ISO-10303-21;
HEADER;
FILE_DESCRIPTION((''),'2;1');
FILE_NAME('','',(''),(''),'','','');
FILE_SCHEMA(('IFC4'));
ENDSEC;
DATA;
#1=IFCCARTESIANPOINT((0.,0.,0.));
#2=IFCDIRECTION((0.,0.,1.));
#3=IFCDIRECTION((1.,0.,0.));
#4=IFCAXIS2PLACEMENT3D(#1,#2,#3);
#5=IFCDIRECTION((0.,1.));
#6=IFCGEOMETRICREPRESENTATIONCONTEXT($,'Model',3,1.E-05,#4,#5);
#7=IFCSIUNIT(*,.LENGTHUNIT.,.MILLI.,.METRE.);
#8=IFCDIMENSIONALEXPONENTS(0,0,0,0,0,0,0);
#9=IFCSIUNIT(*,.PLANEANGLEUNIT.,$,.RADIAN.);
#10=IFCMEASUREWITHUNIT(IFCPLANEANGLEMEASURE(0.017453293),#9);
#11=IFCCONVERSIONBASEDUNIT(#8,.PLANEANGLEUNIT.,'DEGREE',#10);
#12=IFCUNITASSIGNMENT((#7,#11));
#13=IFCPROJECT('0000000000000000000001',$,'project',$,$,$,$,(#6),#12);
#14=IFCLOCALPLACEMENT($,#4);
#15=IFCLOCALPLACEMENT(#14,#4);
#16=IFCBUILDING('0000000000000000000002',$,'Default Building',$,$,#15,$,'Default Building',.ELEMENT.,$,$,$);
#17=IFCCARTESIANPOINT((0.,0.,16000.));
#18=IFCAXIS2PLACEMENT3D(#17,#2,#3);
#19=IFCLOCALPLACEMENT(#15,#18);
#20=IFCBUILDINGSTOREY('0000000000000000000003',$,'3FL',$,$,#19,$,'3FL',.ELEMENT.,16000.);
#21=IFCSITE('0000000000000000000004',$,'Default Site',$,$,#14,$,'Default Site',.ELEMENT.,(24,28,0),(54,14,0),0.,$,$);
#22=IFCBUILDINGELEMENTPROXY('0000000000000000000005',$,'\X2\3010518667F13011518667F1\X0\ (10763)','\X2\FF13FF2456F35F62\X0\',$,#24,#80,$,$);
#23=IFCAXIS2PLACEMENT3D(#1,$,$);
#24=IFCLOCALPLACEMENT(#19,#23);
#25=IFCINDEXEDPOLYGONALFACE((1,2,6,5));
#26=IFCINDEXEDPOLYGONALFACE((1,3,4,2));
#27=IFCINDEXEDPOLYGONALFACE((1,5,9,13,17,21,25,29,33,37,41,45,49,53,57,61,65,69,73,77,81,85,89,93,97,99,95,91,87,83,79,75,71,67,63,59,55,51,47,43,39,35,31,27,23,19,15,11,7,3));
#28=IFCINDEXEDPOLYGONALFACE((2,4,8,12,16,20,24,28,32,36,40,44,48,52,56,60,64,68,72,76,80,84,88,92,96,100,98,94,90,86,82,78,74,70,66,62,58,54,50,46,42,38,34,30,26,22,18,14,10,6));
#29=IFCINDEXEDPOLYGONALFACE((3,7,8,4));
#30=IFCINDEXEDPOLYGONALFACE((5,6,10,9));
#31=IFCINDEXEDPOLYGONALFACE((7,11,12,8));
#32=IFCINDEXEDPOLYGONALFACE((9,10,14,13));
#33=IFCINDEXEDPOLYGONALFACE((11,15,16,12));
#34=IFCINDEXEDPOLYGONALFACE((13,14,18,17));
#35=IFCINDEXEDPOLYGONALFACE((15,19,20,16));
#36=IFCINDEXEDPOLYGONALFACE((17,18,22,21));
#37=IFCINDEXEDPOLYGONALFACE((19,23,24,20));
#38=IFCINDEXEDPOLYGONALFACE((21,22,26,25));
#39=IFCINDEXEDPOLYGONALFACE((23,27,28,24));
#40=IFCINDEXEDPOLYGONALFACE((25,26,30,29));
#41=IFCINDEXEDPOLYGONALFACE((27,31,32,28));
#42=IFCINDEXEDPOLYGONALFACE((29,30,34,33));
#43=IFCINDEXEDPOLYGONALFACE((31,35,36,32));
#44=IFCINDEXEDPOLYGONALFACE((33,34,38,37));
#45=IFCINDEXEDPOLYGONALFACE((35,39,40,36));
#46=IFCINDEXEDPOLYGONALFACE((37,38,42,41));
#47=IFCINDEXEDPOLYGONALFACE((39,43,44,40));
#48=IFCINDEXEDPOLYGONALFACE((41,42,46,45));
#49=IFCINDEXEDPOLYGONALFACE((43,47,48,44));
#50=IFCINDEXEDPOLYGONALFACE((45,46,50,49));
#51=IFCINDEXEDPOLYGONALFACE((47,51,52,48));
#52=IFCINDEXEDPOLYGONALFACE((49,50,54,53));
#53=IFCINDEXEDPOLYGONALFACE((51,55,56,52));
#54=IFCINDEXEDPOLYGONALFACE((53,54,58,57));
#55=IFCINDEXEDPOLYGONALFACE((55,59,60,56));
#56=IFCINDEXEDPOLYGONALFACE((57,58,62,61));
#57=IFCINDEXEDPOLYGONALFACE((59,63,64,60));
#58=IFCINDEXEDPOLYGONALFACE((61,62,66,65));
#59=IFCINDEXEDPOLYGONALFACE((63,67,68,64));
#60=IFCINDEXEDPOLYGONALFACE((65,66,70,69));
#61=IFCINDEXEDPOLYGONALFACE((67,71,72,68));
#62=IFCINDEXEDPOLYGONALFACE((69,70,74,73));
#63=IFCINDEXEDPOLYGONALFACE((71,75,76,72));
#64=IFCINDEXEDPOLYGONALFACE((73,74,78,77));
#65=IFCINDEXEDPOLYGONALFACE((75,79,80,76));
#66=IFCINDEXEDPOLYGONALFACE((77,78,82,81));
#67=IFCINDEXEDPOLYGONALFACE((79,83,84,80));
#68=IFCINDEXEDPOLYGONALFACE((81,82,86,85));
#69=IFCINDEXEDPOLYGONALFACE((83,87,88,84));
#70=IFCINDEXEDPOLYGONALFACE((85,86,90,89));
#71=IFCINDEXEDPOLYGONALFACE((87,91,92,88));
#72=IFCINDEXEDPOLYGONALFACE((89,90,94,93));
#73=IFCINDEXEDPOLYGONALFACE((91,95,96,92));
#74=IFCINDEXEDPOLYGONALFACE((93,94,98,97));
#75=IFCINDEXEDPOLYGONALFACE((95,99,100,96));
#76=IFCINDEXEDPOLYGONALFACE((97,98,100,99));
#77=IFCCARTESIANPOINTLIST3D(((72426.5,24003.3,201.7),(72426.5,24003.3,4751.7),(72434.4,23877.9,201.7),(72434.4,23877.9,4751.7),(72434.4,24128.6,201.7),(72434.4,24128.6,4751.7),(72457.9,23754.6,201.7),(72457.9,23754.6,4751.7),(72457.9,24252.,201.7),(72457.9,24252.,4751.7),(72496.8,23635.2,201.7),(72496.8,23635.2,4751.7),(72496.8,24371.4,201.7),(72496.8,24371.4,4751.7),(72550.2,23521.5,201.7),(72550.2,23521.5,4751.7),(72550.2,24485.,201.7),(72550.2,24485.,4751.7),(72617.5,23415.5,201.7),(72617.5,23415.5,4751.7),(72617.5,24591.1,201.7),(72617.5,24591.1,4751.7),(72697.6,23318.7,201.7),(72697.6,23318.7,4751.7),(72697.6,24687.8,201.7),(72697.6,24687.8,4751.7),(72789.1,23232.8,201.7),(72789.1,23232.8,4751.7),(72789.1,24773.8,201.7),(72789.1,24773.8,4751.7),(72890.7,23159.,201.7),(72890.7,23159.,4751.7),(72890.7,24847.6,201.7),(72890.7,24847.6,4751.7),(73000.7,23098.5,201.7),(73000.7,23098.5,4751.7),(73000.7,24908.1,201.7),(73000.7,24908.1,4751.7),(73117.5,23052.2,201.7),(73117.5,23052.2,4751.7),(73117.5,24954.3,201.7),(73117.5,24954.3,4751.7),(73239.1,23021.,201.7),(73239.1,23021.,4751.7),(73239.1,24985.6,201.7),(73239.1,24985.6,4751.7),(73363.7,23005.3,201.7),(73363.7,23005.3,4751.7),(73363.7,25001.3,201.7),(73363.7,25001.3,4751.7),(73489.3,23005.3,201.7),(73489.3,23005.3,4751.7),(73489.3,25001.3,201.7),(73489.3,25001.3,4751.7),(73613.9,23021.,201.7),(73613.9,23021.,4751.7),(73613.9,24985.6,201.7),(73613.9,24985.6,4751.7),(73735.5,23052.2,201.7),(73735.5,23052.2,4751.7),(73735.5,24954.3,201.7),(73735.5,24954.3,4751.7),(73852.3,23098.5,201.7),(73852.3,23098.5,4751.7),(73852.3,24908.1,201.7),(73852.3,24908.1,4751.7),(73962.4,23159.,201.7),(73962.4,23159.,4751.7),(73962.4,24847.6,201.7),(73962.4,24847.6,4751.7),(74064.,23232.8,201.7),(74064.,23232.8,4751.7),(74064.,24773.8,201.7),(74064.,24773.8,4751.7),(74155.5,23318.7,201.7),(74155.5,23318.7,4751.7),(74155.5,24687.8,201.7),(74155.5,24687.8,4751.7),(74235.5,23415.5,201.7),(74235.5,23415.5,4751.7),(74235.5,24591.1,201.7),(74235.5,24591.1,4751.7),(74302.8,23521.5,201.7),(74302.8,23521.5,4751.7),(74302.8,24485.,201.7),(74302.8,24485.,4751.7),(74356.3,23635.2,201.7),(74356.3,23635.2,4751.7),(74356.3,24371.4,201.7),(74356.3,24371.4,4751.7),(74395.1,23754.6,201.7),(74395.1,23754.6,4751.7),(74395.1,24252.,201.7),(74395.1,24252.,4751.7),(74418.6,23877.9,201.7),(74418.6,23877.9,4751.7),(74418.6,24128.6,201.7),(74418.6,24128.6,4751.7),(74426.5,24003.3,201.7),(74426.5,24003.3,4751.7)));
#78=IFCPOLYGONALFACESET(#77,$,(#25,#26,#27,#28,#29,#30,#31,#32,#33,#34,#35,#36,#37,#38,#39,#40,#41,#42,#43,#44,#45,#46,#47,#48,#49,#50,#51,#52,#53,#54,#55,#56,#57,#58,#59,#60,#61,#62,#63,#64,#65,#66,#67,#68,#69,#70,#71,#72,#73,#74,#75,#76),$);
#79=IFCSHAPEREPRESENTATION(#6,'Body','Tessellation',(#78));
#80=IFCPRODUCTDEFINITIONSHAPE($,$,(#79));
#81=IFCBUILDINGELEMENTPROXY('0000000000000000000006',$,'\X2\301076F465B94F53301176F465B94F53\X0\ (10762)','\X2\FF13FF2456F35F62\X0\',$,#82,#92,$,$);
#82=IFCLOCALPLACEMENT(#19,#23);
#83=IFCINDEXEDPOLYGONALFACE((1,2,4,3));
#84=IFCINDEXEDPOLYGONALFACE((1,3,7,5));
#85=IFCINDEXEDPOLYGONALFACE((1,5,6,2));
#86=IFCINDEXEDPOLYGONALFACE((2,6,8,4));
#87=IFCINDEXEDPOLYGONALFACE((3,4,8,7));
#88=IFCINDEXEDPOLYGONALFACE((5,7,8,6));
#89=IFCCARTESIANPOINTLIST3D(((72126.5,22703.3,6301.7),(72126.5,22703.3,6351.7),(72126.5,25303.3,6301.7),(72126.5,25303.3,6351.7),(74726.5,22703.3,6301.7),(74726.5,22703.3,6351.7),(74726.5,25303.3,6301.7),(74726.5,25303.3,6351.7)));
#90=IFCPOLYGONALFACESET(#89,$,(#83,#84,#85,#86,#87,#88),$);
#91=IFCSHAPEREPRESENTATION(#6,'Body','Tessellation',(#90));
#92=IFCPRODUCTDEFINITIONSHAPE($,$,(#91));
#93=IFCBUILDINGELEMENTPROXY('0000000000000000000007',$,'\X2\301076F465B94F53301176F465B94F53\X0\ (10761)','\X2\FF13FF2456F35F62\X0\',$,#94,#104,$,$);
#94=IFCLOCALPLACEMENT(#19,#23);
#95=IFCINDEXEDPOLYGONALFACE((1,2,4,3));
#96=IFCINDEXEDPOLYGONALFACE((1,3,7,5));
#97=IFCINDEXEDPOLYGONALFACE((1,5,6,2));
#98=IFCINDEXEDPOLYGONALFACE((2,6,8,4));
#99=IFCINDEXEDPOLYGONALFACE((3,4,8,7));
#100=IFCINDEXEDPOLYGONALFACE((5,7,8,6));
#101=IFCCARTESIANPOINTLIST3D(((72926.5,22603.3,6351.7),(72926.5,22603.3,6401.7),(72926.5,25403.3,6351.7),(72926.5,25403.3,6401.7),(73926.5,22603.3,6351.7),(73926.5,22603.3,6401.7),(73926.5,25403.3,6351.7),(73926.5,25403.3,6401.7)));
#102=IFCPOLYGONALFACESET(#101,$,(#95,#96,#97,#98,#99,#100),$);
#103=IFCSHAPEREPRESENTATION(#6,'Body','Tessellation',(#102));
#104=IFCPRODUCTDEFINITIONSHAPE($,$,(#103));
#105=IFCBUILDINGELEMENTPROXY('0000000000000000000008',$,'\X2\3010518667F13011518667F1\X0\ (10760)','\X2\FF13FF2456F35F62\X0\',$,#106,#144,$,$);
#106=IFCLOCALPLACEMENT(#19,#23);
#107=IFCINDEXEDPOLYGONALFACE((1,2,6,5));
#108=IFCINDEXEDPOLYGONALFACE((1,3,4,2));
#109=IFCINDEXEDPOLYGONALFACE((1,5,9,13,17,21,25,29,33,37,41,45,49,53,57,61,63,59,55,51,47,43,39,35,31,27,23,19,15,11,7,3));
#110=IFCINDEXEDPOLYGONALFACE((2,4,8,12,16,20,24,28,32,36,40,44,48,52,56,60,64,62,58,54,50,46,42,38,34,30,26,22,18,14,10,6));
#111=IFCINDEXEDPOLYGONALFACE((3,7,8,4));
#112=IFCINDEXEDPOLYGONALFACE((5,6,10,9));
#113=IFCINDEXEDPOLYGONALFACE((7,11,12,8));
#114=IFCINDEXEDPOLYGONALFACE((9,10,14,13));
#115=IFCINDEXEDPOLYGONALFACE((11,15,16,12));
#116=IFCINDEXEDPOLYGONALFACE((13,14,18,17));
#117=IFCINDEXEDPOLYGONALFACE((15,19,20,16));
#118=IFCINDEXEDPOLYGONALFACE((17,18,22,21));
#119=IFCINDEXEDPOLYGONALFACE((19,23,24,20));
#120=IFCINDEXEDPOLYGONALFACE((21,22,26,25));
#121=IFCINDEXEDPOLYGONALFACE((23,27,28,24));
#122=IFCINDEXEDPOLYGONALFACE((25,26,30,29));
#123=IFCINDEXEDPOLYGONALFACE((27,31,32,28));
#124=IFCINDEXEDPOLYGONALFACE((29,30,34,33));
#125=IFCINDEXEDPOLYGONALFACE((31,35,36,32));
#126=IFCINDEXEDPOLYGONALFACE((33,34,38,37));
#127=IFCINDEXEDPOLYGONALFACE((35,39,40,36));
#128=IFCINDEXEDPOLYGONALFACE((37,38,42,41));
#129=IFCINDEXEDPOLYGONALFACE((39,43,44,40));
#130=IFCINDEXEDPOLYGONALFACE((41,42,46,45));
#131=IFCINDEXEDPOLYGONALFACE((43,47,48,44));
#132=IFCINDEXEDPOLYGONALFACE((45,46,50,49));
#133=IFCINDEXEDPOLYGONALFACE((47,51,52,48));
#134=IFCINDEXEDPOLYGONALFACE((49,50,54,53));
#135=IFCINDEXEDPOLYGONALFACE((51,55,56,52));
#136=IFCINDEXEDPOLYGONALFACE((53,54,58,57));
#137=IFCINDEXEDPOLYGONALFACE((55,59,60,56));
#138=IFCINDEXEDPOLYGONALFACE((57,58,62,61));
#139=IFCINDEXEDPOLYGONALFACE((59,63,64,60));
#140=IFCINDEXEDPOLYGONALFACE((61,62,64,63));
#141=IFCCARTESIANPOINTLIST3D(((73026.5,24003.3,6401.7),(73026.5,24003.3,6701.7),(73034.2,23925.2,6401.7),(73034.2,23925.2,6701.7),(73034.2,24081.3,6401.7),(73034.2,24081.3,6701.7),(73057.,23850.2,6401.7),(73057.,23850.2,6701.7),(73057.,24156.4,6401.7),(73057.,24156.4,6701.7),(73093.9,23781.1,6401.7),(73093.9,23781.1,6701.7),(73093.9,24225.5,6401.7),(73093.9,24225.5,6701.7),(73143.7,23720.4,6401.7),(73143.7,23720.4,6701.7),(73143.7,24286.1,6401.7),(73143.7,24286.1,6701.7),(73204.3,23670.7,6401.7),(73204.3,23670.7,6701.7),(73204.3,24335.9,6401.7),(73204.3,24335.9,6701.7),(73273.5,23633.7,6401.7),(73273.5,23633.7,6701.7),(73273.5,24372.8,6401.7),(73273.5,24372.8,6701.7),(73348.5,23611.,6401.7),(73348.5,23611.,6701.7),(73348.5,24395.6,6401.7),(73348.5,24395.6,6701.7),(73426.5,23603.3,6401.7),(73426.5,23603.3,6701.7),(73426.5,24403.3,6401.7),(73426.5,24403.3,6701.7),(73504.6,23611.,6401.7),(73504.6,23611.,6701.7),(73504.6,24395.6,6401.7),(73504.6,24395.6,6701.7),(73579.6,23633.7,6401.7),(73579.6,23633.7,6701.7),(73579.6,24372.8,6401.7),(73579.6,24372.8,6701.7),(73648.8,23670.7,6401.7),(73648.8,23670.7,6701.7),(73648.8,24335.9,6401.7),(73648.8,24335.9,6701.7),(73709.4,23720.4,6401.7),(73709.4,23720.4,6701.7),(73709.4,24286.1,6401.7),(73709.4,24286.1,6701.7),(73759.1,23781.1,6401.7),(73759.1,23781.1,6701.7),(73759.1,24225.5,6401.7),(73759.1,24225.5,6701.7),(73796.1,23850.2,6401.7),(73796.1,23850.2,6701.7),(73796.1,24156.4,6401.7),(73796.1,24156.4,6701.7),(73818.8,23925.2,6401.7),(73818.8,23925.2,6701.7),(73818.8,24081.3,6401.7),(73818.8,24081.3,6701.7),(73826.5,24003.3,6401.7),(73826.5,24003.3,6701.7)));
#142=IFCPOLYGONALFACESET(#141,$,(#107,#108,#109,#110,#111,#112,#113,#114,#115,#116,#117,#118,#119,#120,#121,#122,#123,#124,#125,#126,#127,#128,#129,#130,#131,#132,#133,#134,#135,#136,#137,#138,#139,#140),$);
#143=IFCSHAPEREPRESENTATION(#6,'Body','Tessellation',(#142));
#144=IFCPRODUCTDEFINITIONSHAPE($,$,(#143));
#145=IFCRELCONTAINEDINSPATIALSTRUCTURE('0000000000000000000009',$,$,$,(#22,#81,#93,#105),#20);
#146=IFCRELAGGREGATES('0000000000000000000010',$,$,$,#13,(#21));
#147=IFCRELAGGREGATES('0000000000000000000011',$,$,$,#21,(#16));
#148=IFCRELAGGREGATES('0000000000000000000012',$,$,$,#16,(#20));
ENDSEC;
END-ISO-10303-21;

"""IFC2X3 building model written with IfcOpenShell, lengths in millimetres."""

from ifc_helpers import new_model, entity, si_unit, converted_unit, direction, frame, origin_with_axes, origin_2d_with_axis, place, context, project, spatial, rectangle, circle, extrude, source, transform, mapped, element, save


model = new_model("IFC2X3")

# Units and contexts
model_context = context("Model", 3, precision=1e-05, world=origin_with_axes(), true_north=direction((0.0, 1.0)))
ifc_project = project(units=[si_unit("LENGTHUNIT", "METRE", prefix="MILLI"), converted_unit("PLANEANGLEUNIT", "DEGREE", entity("IfcPlaneAngleMeasure", 0.017453293), si_unit("PLANEANGLEUNIT", "RADIAN"), dimensions=[0, 0, 0, 0, 0, 0, 0])], contexts=[model_context])

# Site, building, storey
site_placement = place(None, origin_with_axes())
site = spatial("IfcSite", under=ifc_project, at=site_placement, Name="Default Site", LongName="Default Site", CompositionType="ELEMENT", RefLatitude=(24, 28, 0), RefLongitude=(54, 14, 0), RefElevation=0.0)
building_placement = place(site_placement, origin_with_axes())
building = spatial("IfcBuilding", under=site, at=building_placement, Name="Default Building", LongName="Default Building", CompositionType="ELEMENT")
storey_placement = place(building_placement, frame((0.0, 0.0, 16000.0), z_axis=(0.0, 0.0, 1.0), x_axis=(1.0, 0.0, 0.0)))
storey = spatial("IfcBuildingStorey", under=building, at=storey_placement, Name="3FL", LongName="3FL", CompositionType="ELEMENT", Elevation=16000.0)

# Building element proxies
shared_shape_1 = source(origin_with_axes(), model_context, "Body", "SweptSolid", [
    extrude(circle(Radius=1000.0, at=origin_2d_with_axis()), origin_with_axes(), (0.0, 0.0, 1.0), 4550.0),
])
proxy_1_placement = place(storey_placement, frame((73426.5, 24003.3, 201.7), z_axis=(0.0, 0.0, 1.0), x_axis=(1.0, 0.0, 0.0)))
element("IfcBuildingElementProxy", 1, at=proxy_1_placement, inside=storey, Name="【円柱】円柱 (10763)", Description="３Ｄ図形", context=model_context, shape_type="MappedRepresentation", body=[
    mapped(shared_shape_1, transform((0.0, 0.0, 0.0))),
])
shared_shape_2 = source(origin_with_axes(), model_context, "Body", "SweptSolid", [
    extrude(rectangle(XDim=2600.0, YDim=2600.0, at=origin_2d_with_axis()), origin_with_axes(), (0.0, 0.0, 1.0), 50.0),
])
proxy_2_placement = place(storey_placement, frame((73426.5, 24003.3, 6301.7), z_axis=(0.0, 0.0, 1.0), x_axis=(1.0, 0.0, 0.0)))
element("IfcBuildingElementProxy", 2, at=proxy_2_placement, inside=storey, Name="【直方体】直方体 (10762)", Description="３Ｄ図形", context=model_context, shape_type="MappedRepresentation", body=[
    mapped(shared_shape_2, transform((0.0, 0.0, 0.0))),
])
shared_shape_3 = source(origin_with_axes(), model_context, "Body", "SweptSolid", [
    extrude(rectangle(XDim=1000.0, YDim=2800.0, at=origin_2d_with_axis()), origin_with_axes(), (0.0, 0.0, 1.0), 50.0),
])
proxy_3_placement = place(storey_placement, frame((73426.5, 24003.3, 6351.7), z_axis=(0.0, 0.0, 1.0), x_axis=(1.0, 0.0, 0.0)))
element("IfcBuildingElementProxy", 3, at=proxy_3_placement, inside=storey, Name="【直方体】直方体 (10761)", Description="３Ｄ図形", context=model_context, shape_type="MappedRepresentation", body=[
    mapped(shared_shape_3, transform((0.0, 0.0, 0.0))),
])
shared_shape_4 = source(origin_with_axes(), model_context, "Body", "SweptSolid", [
    extrude(circle(Radius=400.0, at=origin_2d_with_axis()), origin_with_axes(), (0.0, 0.0, 1.0), 300.0),
])
proxy_4_placement = place(storey_placement, frame((73426.5, 24003.3, 6401.7), z_axis=(0.0, 0.0, 1.0), x_axis=(1.0, 0.0, 0.0)))
element("IfcBuildingElementProxy", 4, at=proxy_4_placement, inside=storey, Name="【円柱】円柱 (10760)", Description="３Ｄ図形", context=model_context, shape_type="MappedRepresentation", body=[
    mapped(shared_shape_4, transform((0.0, 0.0, 0.0))),
])

save(model, "model.ifc")
